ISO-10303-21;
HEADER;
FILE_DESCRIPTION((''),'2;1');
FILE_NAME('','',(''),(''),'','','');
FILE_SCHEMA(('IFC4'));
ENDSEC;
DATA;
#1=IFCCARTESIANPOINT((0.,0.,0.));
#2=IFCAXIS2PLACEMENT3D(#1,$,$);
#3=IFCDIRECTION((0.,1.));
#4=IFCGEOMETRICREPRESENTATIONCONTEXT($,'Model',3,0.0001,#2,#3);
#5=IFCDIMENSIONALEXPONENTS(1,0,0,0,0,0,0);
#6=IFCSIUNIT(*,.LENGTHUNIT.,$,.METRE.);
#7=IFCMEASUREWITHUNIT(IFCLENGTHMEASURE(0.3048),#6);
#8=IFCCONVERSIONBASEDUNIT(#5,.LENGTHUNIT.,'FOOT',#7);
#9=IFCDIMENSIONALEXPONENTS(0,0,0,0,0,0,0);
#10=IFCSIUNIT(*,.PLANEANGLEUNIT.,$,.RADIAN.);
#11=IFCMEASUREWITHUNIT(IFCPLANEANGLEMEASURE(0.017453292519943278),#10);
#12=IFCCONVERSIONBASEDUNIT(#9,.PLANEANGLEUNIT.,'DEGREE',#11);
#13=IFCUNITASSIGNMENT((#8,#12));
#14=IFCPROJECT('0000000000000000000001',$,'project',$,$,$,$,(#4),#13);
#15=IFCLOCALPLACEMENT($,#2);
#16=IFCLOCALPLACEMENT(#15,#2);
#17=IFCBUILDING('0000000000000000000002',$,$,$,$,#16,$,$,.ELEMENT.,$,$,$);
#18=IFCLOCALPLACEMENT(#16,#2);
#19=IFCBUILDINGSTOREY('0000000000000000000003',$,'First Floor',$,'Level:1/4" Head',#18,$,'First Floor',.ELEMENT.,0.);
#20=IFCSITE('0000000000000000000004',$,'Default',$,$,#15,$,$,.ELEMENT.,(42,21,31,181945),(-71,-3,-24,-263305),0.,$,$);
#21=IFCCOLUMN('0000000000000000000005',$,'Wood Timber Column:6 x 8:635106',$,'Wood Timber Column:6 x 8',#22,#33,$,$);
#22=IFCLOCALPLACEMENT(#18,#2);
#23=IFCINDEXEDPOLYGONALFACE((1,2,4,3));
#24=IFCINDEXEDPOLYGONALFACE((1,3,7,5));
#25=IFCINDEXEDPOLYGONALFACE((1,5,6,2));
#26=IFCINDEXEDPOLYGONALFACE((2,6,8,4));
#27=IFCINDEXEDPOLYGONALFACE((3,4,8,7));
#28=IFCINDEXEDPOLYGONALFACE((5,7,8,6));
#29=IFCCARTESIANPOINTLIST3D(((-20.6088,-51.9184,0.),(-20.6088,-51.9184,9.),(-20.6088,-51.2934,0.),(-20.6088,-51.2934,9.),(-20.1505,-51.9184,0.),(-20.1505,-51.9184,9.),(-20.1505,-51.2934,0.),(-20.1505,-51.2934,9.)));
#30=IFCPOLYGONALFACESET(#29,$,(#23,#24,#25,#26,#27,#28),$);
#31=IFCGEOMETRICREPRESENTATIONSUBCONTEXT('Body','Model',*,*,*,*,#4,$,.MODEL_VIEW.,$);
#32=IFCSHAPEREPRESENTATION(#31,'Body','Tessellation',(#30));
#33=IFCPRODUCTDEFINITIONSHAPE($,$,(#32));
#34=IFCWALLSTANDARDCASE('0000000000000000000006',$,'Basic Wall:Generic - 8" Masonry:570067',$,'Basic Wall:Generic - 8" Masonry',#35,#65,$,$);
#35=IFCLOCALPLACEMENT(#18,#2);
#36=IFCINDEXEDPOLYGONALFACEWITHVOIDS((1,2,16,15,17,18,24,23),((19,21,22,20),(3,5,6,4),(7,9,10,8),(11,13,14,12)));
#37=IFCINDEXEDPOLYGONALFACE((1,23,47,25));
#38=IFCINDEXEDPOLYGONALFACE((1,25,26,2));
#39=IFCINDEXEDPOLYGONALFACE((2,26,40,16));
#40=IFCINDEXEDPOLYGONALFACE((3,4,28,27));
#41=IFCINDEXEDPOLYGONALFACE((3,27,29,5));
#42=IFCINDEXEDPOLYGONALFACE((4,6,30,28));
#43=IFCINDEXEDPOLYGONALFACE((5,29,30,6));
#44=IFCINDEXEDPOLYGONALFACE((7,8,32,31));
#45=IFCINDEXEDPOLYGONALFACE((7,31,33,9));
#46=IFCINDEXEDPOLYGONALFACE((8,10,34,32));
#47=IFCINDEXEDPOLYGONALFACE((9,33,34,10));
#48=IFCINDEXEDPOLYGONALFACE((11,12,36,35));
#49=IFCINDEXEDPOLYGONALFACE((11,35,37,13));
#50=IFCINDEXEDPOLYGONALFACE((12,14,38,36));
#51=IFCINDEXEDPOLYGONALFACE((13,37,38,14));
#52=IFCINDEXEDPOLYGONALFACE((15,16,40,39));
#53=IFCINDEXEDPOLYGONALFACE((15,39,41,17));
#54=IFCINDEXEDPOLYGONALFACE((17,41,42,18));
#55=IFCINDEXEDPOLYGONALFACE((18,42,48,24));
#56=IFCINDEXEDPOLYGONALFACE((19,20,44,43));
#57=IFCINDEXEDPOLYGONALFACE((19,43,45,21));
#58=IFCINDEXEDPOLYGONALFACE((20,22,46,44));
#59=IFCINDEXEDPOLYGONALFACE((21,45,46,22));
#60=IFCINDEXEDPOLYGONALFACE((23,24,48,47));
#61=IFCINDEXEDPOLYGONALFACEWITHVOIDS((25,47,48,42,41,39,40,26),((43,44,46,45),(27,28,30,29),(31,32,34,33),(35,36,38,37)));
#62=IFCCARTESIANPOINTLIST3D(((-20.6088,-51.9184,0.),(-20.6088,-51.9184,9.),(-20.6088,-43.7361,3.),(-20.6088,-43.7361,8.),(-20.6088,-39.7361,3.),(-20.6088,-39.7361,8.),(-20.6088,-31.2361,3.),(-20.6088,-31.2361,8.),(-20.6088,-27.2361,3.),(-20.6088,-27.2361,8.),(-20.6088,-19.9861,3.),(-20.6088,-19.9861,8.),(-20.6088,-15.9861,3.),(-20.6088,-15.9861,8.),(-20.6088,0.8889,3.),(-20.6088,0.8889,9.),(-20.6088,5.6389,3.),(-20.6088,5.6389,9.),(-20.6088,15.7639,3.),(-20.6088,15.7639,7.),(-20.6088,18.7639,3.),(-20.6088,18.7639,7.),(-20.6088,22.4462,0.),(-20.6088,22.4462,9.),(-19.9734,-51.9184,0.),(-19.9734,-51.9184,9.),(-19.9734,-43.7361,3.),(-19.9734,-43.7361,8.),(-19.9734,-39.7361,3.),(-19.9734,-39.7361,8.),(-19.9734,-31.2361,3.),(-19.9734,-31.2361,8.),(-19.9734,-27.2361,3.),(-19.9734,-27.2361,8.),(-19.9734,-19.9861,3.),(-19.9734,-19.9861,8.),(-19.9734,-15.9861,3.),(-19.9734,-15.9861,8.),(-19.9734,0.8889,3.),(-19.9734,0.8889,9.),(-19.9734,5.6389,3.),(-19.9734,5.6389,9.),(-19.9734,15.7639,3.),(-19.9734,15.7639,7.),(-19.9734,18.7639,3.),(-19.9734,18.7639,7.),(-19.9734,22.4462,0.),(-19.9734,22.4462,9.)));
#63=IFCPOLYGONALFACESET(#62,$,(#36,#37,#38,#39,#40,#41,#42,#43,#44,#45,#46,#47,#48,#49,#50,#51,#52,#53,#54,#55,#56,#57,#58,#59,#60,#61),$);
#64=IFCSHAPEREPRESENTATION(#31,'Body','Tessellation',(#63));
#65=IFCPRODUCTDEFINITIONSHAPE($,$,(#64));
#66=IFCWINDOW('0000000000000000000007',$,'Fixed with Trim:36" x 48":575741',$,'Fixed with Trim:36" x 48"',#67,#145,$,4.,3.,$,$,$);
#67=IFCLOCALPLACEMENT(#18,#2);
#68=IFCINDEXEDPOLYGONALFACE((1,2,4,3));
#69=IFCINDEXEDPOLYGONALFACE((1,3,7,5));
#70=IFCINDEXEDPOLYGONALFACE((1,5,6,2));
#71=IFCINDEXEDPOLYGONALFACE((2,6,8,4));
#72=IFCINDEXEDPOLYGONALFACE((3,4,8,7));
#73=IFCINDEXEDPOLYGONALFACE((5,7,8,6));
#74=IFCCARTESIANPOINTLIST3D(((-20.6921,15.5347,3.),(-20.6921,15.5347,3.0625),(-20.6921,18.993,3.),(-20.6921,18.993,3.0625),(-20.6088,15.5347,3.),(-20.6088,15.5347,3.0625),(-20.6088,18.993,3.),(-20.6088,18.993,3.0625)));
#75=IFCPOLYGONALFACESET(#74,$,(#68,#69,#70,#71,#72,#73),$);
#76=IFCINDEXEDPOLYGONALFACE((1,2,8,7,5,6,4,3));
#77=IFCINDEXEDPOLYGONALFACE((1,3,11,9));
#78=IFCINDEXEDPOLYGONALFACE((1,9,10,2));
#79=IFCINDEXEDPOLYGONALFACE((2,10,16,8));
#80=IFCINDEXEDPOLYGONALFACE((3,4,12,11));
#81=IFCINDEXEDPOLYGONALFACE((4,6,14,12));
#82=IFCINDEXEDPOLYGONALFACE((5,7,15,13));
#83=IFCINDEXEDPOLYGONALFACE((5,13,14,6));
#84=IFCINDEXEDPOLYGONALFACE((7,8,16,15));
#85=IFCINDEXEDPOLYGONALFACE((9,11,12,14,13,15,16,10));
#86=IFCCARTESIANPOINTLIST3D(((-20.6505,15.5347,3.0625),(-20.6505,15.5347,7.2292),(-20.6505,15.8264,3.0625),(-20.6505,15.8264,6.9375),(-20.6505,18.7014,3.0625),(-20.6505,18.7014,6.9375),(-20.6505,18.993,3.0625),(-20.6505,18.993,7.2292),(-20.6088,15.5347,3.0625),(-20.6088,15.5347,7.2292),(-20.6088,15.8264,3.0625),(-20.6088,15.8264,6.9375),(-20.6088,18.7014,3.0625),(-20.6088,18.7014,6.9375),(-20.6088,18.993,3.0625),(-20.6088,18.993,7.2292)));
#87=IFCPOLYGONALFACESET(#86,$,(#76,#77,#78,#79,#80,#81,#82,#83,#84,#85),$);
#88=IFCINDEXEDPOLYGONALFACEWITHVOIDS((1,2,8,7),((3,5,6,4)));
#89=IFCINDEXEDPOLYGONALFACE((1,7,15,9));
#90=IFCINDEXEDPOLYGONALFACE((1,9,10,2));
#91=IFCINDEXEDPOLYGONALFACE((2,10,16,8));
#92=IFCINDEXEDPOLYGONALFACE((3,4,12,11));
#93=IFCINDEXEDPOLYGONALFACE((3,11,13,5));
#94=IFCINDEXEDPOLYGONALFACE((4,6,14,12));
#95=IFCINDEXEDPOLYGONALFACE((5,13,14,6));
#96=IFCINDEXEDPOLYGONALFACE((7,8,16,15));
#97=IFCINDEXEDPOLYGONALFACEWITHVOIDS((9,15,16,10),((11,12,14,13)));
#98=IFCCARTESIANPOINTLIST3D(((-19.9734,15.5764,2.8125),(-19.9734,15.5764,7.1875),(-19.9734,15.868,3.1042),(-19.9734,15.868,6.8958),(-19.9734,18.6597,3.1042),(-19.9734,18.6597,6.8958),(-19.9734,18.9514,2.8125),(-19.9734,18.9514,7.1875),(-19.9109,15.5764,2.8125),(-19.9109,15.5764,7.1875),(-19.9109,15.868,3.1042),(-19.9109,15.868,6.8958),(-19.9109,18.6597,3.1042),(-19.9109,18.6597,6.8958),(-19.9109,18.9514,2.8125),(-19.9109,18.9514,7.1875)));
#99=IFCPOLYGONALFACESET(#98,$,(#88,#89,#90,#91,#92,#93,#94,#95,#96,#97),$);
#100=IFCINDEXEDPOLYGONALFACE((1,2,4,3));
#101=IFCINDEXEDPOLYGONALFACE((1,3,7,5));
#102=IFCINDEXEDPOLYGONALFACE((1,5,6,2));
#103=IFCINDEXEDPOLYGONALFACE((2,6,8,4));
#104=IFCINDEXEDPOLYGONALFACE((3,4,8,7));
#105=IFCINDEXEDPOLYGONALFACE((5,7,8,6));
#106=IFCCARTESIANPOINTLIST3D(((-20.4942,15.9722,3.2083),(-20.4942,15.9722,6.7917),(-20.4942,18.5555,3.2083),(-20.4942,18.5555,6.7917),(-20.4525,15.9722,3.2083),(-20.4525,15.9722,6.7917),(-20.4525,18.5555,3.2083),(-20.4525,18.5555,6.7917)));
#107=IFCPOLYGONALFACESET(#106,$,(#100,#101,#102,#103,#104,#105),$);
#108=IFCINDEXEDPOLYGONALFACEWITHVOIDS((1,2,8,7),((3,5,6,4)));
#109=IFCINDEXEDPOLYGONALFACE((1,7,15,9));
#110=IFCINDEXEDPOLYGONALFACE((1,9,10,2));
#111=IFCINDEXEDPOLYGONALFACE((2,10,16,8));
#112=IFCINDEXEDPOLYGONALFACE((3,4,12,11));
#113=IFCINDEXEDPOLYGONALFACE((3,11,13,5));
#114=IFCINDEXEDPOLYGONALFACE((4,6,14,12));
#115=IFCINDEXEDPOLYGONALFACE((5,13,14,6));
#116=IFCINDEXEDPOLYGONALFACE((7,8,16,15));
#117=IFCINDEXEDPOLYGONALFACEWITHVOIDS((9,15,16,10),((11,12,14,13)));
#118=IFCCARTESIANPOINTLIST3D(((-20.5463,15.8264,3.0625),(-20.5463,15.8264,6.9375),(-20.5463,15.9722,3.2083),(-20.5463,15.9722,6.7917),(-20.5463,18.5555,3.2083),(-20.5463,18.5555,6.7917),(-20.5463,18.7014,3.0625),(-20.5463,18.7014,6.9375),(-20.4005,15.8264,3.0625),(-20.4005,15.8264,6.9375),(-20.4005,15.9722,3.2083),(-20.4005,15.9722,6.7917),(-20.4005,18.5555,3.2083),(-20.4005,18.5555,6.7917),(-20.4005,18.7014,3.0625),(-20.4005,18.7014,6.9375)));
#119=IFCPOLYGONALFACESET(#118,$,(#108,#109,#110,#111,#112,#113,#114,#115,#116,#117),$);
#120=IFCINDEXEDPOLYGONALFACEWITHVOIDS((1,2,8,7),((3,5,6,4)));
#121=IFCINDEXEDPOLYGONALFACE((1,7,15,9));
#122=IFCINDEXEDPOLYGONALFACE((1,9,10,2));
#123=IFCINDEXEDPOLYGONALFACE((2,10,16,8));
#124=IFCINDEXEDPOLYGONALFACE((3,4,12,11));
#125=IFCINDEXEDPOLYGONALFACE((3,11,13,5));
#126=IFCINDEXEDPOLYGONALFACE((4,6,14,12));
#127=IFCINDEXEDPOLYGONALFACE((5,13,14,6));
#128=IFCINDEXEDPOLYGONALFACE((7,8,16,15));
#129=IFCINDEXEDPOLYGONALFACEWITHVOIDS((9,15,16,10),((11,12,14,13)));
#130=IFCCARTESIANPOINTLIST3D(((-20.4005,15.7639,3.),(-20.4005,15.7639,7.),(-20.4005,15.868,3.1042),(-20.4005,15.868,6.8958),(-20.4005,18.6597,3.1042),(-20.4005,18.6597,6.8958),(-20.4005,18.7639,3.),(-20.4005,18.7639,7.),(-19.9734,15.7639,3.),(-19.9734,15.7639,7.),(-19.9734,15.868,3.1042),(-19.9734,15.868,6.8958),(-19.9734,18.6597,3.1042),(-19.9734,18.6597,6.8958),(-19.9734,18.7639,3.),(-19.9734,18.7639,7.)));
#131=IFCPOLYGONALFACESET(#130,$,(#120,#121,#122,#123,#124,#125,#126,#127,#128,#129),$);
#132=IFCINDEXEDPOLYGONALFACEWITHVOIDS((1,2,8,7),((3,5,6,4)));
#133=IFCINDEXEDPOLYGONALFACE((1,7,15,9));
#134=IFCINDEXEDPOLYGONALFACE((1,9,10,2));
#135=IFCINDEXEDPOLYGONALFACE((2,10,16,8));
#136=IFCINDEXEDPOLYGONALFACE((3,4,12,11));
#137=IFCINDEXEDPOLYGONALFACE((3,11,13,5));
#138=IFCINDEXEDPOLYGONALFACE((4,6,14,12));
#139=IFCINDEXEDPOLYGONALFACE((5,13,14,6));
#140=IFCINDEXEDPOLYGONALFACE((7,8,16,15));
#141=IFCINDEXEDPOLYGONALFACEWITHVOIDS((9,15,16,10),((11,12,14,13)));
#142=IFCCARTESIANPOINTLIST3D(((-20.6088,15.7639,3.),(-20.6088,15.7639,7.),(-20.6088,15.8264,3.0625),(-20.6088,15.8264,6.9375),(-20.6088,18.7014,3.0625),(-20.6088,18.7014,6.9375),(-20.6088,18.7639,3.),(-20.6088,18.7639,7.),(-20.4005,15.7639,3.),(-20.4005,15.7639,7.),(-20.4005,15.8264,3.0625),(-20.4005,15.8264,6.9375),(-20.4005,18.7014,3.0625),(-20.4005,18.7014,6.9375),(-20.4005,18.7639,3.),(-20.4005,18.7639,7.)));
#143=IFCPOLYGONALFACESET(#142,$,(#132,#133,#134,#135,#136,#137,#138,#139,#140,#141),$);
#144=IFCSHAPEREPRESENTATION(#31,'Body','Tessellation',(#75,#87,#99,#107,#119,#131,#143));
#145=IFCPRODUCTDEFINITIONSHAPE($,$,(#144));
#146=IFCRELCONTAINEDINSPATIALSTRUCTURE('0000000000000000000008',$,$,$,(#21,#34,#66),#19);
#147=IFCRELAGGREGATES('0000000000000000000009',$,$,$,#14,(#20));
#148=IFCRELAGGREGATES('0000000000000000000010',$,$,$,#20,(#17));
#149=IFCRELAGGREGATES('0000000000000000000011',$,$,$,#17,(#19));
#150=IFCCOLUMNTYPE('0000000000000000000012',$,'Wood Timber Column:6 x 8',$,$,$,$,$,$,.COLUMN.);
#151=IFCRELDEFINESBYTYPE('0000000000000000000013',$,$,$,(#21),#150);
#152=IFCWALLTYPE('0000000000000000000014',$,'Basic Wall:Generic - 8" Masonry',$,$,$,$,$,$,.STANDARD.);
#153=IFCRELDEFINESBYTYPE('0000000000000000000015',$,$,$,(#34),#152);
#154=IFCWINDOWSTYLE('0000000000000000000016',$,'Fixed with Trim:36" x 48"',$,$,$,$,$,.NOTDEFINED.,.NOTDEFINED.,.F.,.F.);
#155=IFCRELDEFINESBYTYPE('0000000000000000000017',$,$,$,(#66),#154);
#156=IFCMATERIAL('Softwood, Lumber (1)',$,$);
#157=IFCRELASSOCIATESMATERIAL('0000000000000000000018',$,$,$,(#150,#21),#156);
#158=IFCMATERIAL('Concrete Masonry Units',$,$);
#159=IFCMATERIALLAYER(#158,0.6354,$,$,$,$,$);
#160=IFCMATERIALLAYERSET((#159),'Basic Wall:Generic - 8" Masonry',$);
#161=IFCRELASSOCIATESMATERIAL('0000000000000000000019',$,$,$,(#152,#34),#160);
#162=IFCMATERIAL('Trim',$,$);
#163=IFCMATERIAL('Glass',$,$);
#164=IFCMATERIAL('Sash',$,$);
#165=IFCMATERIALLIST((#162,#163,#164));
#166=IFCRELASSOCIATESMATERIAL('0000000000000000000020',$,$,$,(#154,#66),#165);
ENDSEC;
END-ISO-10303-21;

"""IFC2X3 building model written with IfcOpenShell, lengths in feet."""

from ifc_helpers import new_model, entity, si_unit, converted_unit, direction, frame, frame_2d, origin, origin_2d_with_axis, place, context, subcontext, project, spatial, polyline, rectangle, outline, extrude, source, transform, mapped, material, material_list, layer, layer_set, layer_usage, type_object, type_shapes, element, fill, save


model = new_model("IFC2X3")

# Units and contexts
model_context = context("Model", 3, precision=0.0001, world=origin(), true_north=direction((0.0, 1.0)))
body_context = subcontext(model_context, "Body", "Model", "MODEL_VIEW")
ifc_project = project(units=[converted_unit("LENGTHUNIT", "FOOT", entity("IfcLengthMeasure", 0.3048), si_unit("LENGTHUNIT", "METRE"), dimensions=[1, 0, 0, 0, 0, 0, 0]), converted_unit("PLANEANGLEUNIT", "DEGREE", entity("IfcPlaneAngleMeasure", 0.017453292519943278), si_unit("PLANEANGLEUNIT", "RADIAN"), dimensions=[0, 0, 0, 0, 0, 0, 0])], contexts=[model_context])

# Site, building, storey
site_placement = place(None, origin())
site = spatial("IfcSite", under=ifc_project, at=site_placement, Name="Default", CompositionType="ELEMENT", RefLatitude=(42, 21, 31, 181945), RefLongitude=(-71, -3, -24, -263305), RefElevation=0.0)
building_placement = place(site_placement, origin())
building = spatial("IfcBuilding", under=site, at=building_placement, CompositionType="ELEMENT")
storey_placement = place(building_placement, origin())
storey = spatial("IfcBuildingStorey", under=building, at=storey_placement, Name="First Floor", ObjectType="Level:1/4\" Head", LongName="First Floor", CompositionType="ELEMENT", Elevation=0.0)

# Column
ifc_material_1 = material(Name="Softwood, Lumber (1)")
column_type = type_object("IfcColumnType", Name="Wood Timber Column:6 x 8", PredefinedType="COLUMN", material=ifc_material_1)
shared_shape_1 = source(origin(), body_context, "Body", "SweptSolid", [
    extrude(rectangle(XDim=0.625, YDim=0.4583, at=origin_2d_with_axis()), frame((0.0, 0.0, 0.0), z_axis=(0.0, 0.0, 1.0), x_axis=(0.0, 1.0, 0.0)), (0.0, 0.0, 1.0), 9.0),
])
type_shapes(column_type, [shared_shape_1])
column_placement = place(storey_placement, frame((-20.3796, -51.6059, 0.0)))
element("IfcColumn", 1, at=column_placement, inside=storey, type_object=column_type, material=ifc_material_1, Name="Wood Timber Column:6 x 8:635106", ObjectType="Wood Timber Column:6 x 8", context=body_context, shape_type="MappedRepresentation", body=[
    mapped(shared_shape_1, transform((0.0, 0.0, 0.0), scale=1.0)),
])

# Wall, openings, window
ifc_material_2 = material(Name="Concrete Masonry Units")
ifc_layer = layer(ifc_material_2, 0.6354)
ifc_layer_set = layer_set([ifc_layer], Name="Basic Wall:Generic - 8\" Masonry")
ifc_layer_usage_1 = layer_usage(ifc_layer_set, "AXIS2", "NEGATIVE", 0.3177)
wall_type = type_object("IfcWallType", Name="Basic Wall:Generic - 8\" Masonry", PredefinedType="STANDARD", material=ifc_layer_set)
wall_1_placement = place(storey_placement, frame((-20.2911, -51.9184, 0.0), z_axis=(0.0, 0.0, 1.0), x_axis=(0.0, 1.0, 0.0)))
wall_1 = element("IfcWallStandardCase", 2, at=wall_1_placement, inside=storey, type_object=wall_type, material=ifc_layer_usage_1, Name="Basic Wall:Generic - 8\" Masonry:570067", ObjectType="Basic Wall:Generic - 8\" Masonry", context=body_context, shape_type="SweptSolid", body=[
    extrude(rectangle(XDim=74.3646, YDim=0.6354, at=frame_2d((37.1823, 0.0), x_axis=(-1.0, 0.0))), origin(), (0.0, 0.0, 1.0), 9.0),
])
opening_1_placement = place(wall_1_placement, frame((52.8073, -0.3177, 3.0)))
element("IfcOpeningElement", 3, at=opening_1_placement, cuts=wall_1, ObjectType="Opening", context=body_context, shape_type="SweptSolid", body=[
    extrude(rectangle(XDim=6.0, YDim=4.75, at=frame_2d((3.0, 2.375), x_axis=(-1.0, 0.0))), frame((0.0, 0.0, 0.0), z_axis=(0.0, 1.0, 0.0), x_axis=(0.0, 0.0, 1.0)), (0.0, 0.0, 1.0), 0.6354),
])
opening_2_placement = place(wall_1_placement, frame((8.1823, -0.3177, 3.0)))
element("IfcOpeningElement", 4, at=opening_2_placement, cuts=wall_1, ObjectType="Opening", context=body_context, shape_type="SweptSolid", body=[
    extrude(rectangle(XDim=5.0, YDim=4.0, at=frame_2d((2.5, 2.0), x_axis=(-1.0, 0.0))), frame((0.0, 0.0, 0.0), z_axis=(0.0, 1.0, 0.0), x_axis=(0.0, 0.0, 1.0)), (0.0, 0.0, 1.0), 0.6354),
])
opening_3_placement = place(wall_1_placement, frame((20.6823, -0.3177, 3.0)))
element("IfcOpeningElement", 5, at=opening_3_placement, cuts=wall_1, ObjectType="Opening", context=body_context, shape_type="SweptSolid", body=[
    extrude(rectangle(XDim=5.0, YDim=4.0, at=frame_2d((2.5, 2.0), x_axis=(-1.0, 0.0))), frame((0.0, 0.0, 0.0), z_axis=(0.0, 1.0, 0.0), x_axis=(0.0, 0.0, 1.0)), (0.0, 0.0, 1.0), 0.6354),
])
opening_4_placement = place(wall_1_placement, frame((31.9323, -0.3177, 3.0)))
element("IfcOpeningElement", 6, at=opening_4_placement, cuts=wall_1, ObjectType="Opening", context=body_context, shape_type="SweptSolid", body=[
    extrude(rectangle(XDim=5.0, YDim=4.0, at=frame_2d((2.5, 2.0), x_axis=(-1.0, 0.0))), frame((0.0, 0.0, 0.0), z_axis=(0.0, 1.0, 0.0), x_axis=(0.0, 0.0, 1.0)), (0.0, 0.0, 1.0), 0.6354),
])
opening_5_placement = place(wall_1_placement, frame((67.6823, -0.3177, 3.0)))
opening_5 = element("IfcOpeningElement", 7, at=opening_5_placement, cuts=wall_1, ObjectType="Opening", context=body_context, shape_type="SweptSolid", body=[
    extrude(rectangle(XDim=4.0, YDim=3.0, at=frame_2d((2.0, 1.5), x_axis=(-1.0, 0.0))), frame((0.0, 0.0, 0.0), z_axis=(0.0, 1.0, 0.0), x_axis=(0.0, 0.0, 1.0)), (0.0, 0.0, 1.0), 0.6354),
])
ifc_material_3 = material(Name="Trim")
ifc_material_4 = material(Name="Glass")
ifc_material_5 = material(Name="Sash")
ifc_material_list_1 = material_list([ifc_material_3, ifc_material_4, ifc_material_5])
window_style = type_object("IfcWindowStyle", Name="Fixed with Trim:36\" x 48\"", ConstructionType="NOTDEFINED", OperationType="NOTDEFINED", ParameterTakesPrecedence=False, Sizeable=False, material=ifc_material_list_1)
shared_shape_2 = source(origin(), body_context, "Body", "SweptSolid", [
    extrude(rectangle(XDim=0.0833, YDim=3.4583, at=origin_2d_with_axis()), frame((1.5, 0.6771, 0.0), z_axis=(0.0, 0.0, 1.0), x_axis=(0.0, -1.0, 0.0)), (0.0, 0.0, 1.0), 0.0625),
    extrude(outline(polyline([(-1.8646, 1.4375), (2.0104, 1.4375), (2.0104, 1.7292), (-2.1562, 1.7292), (-2.1562, -1.7292), (2.0104, -1.7292), (2.0104, -1.4375), (-1.8646, -1.4375), (-1.8646, 1.4375)])), frame((1.5, 0.6354, 2.0729), z_axis=(0.0, 1.0, 0.0), x_axis=(0.0, 0.0, -1.0)), (0.0, 0.0, 1.0), 0.0417),
    extrude(outline(polyline([(-2.1875, -1.6875), (2.1875, -1.6875), (2.1875, 1.6875), (-2.1875, 1.6875), (-2.1875, -1.6875)]), holes=[polyline([(-1.8958, -1.3958), (-1.8958, 1.3958), (1.8958, 1.3958), (1.8958, -1.3958), (-1.8958, -1.3958)])]), frame((1.5, -0.0625, 2.0), z_axis=(0.0, 1.0, 0.0), x_axis=(0.0, 0.0, -1.0)), (0.0, 0.0, 1.0), 0.0625),
    extrude(rectangle(XDim=0.0417, YDim=2.5833, at=frame_2d((0.0, 0.0), x_axis=(1.0, 0.0))), frame((1.5, 0.5, 0.2083), z_axis=(0.0, 0.0, 1.0), x_axis=(0.0, 1.0, 0.0)), (0.0, 0.0, 1.0), 3.5833),
    extrude(outline(polyline([(-1.4375, -1.9375), (1.4375, -1.9375), (1.4375, 1.9375), (-1.4375, 1.9375), (-1.4375, -1.9375)]), holes=[polyline([(-1.2917, -1.7917), (-1.2917, 1.7917), (1.2917, 1.7917), (1.2917, -1.7917), (-1.2917, -1.7917)])]), frame((1.5, 0.4271, 2.0), z_axis=(0.0, 1.0, 0.0), x_axis=(1.0, 0.0, 0.0)), (0.0, 0.0, 1.0), 0.1458),
    extrude(outline(polyline([(-1.5, -2.0), (1.5, -2.0), (1.5, 2.0), (-1.5, 2.0), (-1.5, -2.0)]), holes=[polyline([(-1.3958, -1.8958), (-1.3958, 1.8958), (1.3958, 1.8958), (1.3958, -1.8958), (-1.3958, -1.8958)])]), frame((1.5, 0.0, 2.0), z_axis=(0.0, 1.0, 0.0), x_axis=(1.0, 0.0, 0.0)), (0.0, 0.0, 1.0), 0.4271),
    extrude(outline(polyline([(-2.0, -1.5), (2.0, -1.5), (2.0, 1.5), (-2.0, 1.5), (-2.0, -1.5)]), holes=[polyline([(-1.9375, -1.4375), (-1.9375, 1.4375), (1.9375, 1.4375), (1.9375, -1.4375), (-1.9375, -1.4375)])]), frame((1.5, 0.4271, 2.0), z_axis=(0.0, 1.0, 0.0), x_axis=(0.0, 0.0, -1.0)), (0.0, 0.0, 1.0), 0.2083),
])
type_shapes(window_style, [shared_shape_2])
window_placement = place(opening_5_placement, origin())
window = element("IfcWindow", 8, at=window_placement, inside=storey, type_object=window_style, material=ifc_material_list_1, Name="Fixed with Trim:36\" x 48\":575741", ObjectType="Fixed with Trim:36\" x 48\"", OverallHeight=4.0, OverallWidth=3.0, context=body_context, shape_type="MappedRepresentation", body=[
    mapped(shared_shape_2, transform((0.0, 0.0, 0.0), scale=1.0)),
])
fill(opening_5, window)

save(model, "model.ifc")
